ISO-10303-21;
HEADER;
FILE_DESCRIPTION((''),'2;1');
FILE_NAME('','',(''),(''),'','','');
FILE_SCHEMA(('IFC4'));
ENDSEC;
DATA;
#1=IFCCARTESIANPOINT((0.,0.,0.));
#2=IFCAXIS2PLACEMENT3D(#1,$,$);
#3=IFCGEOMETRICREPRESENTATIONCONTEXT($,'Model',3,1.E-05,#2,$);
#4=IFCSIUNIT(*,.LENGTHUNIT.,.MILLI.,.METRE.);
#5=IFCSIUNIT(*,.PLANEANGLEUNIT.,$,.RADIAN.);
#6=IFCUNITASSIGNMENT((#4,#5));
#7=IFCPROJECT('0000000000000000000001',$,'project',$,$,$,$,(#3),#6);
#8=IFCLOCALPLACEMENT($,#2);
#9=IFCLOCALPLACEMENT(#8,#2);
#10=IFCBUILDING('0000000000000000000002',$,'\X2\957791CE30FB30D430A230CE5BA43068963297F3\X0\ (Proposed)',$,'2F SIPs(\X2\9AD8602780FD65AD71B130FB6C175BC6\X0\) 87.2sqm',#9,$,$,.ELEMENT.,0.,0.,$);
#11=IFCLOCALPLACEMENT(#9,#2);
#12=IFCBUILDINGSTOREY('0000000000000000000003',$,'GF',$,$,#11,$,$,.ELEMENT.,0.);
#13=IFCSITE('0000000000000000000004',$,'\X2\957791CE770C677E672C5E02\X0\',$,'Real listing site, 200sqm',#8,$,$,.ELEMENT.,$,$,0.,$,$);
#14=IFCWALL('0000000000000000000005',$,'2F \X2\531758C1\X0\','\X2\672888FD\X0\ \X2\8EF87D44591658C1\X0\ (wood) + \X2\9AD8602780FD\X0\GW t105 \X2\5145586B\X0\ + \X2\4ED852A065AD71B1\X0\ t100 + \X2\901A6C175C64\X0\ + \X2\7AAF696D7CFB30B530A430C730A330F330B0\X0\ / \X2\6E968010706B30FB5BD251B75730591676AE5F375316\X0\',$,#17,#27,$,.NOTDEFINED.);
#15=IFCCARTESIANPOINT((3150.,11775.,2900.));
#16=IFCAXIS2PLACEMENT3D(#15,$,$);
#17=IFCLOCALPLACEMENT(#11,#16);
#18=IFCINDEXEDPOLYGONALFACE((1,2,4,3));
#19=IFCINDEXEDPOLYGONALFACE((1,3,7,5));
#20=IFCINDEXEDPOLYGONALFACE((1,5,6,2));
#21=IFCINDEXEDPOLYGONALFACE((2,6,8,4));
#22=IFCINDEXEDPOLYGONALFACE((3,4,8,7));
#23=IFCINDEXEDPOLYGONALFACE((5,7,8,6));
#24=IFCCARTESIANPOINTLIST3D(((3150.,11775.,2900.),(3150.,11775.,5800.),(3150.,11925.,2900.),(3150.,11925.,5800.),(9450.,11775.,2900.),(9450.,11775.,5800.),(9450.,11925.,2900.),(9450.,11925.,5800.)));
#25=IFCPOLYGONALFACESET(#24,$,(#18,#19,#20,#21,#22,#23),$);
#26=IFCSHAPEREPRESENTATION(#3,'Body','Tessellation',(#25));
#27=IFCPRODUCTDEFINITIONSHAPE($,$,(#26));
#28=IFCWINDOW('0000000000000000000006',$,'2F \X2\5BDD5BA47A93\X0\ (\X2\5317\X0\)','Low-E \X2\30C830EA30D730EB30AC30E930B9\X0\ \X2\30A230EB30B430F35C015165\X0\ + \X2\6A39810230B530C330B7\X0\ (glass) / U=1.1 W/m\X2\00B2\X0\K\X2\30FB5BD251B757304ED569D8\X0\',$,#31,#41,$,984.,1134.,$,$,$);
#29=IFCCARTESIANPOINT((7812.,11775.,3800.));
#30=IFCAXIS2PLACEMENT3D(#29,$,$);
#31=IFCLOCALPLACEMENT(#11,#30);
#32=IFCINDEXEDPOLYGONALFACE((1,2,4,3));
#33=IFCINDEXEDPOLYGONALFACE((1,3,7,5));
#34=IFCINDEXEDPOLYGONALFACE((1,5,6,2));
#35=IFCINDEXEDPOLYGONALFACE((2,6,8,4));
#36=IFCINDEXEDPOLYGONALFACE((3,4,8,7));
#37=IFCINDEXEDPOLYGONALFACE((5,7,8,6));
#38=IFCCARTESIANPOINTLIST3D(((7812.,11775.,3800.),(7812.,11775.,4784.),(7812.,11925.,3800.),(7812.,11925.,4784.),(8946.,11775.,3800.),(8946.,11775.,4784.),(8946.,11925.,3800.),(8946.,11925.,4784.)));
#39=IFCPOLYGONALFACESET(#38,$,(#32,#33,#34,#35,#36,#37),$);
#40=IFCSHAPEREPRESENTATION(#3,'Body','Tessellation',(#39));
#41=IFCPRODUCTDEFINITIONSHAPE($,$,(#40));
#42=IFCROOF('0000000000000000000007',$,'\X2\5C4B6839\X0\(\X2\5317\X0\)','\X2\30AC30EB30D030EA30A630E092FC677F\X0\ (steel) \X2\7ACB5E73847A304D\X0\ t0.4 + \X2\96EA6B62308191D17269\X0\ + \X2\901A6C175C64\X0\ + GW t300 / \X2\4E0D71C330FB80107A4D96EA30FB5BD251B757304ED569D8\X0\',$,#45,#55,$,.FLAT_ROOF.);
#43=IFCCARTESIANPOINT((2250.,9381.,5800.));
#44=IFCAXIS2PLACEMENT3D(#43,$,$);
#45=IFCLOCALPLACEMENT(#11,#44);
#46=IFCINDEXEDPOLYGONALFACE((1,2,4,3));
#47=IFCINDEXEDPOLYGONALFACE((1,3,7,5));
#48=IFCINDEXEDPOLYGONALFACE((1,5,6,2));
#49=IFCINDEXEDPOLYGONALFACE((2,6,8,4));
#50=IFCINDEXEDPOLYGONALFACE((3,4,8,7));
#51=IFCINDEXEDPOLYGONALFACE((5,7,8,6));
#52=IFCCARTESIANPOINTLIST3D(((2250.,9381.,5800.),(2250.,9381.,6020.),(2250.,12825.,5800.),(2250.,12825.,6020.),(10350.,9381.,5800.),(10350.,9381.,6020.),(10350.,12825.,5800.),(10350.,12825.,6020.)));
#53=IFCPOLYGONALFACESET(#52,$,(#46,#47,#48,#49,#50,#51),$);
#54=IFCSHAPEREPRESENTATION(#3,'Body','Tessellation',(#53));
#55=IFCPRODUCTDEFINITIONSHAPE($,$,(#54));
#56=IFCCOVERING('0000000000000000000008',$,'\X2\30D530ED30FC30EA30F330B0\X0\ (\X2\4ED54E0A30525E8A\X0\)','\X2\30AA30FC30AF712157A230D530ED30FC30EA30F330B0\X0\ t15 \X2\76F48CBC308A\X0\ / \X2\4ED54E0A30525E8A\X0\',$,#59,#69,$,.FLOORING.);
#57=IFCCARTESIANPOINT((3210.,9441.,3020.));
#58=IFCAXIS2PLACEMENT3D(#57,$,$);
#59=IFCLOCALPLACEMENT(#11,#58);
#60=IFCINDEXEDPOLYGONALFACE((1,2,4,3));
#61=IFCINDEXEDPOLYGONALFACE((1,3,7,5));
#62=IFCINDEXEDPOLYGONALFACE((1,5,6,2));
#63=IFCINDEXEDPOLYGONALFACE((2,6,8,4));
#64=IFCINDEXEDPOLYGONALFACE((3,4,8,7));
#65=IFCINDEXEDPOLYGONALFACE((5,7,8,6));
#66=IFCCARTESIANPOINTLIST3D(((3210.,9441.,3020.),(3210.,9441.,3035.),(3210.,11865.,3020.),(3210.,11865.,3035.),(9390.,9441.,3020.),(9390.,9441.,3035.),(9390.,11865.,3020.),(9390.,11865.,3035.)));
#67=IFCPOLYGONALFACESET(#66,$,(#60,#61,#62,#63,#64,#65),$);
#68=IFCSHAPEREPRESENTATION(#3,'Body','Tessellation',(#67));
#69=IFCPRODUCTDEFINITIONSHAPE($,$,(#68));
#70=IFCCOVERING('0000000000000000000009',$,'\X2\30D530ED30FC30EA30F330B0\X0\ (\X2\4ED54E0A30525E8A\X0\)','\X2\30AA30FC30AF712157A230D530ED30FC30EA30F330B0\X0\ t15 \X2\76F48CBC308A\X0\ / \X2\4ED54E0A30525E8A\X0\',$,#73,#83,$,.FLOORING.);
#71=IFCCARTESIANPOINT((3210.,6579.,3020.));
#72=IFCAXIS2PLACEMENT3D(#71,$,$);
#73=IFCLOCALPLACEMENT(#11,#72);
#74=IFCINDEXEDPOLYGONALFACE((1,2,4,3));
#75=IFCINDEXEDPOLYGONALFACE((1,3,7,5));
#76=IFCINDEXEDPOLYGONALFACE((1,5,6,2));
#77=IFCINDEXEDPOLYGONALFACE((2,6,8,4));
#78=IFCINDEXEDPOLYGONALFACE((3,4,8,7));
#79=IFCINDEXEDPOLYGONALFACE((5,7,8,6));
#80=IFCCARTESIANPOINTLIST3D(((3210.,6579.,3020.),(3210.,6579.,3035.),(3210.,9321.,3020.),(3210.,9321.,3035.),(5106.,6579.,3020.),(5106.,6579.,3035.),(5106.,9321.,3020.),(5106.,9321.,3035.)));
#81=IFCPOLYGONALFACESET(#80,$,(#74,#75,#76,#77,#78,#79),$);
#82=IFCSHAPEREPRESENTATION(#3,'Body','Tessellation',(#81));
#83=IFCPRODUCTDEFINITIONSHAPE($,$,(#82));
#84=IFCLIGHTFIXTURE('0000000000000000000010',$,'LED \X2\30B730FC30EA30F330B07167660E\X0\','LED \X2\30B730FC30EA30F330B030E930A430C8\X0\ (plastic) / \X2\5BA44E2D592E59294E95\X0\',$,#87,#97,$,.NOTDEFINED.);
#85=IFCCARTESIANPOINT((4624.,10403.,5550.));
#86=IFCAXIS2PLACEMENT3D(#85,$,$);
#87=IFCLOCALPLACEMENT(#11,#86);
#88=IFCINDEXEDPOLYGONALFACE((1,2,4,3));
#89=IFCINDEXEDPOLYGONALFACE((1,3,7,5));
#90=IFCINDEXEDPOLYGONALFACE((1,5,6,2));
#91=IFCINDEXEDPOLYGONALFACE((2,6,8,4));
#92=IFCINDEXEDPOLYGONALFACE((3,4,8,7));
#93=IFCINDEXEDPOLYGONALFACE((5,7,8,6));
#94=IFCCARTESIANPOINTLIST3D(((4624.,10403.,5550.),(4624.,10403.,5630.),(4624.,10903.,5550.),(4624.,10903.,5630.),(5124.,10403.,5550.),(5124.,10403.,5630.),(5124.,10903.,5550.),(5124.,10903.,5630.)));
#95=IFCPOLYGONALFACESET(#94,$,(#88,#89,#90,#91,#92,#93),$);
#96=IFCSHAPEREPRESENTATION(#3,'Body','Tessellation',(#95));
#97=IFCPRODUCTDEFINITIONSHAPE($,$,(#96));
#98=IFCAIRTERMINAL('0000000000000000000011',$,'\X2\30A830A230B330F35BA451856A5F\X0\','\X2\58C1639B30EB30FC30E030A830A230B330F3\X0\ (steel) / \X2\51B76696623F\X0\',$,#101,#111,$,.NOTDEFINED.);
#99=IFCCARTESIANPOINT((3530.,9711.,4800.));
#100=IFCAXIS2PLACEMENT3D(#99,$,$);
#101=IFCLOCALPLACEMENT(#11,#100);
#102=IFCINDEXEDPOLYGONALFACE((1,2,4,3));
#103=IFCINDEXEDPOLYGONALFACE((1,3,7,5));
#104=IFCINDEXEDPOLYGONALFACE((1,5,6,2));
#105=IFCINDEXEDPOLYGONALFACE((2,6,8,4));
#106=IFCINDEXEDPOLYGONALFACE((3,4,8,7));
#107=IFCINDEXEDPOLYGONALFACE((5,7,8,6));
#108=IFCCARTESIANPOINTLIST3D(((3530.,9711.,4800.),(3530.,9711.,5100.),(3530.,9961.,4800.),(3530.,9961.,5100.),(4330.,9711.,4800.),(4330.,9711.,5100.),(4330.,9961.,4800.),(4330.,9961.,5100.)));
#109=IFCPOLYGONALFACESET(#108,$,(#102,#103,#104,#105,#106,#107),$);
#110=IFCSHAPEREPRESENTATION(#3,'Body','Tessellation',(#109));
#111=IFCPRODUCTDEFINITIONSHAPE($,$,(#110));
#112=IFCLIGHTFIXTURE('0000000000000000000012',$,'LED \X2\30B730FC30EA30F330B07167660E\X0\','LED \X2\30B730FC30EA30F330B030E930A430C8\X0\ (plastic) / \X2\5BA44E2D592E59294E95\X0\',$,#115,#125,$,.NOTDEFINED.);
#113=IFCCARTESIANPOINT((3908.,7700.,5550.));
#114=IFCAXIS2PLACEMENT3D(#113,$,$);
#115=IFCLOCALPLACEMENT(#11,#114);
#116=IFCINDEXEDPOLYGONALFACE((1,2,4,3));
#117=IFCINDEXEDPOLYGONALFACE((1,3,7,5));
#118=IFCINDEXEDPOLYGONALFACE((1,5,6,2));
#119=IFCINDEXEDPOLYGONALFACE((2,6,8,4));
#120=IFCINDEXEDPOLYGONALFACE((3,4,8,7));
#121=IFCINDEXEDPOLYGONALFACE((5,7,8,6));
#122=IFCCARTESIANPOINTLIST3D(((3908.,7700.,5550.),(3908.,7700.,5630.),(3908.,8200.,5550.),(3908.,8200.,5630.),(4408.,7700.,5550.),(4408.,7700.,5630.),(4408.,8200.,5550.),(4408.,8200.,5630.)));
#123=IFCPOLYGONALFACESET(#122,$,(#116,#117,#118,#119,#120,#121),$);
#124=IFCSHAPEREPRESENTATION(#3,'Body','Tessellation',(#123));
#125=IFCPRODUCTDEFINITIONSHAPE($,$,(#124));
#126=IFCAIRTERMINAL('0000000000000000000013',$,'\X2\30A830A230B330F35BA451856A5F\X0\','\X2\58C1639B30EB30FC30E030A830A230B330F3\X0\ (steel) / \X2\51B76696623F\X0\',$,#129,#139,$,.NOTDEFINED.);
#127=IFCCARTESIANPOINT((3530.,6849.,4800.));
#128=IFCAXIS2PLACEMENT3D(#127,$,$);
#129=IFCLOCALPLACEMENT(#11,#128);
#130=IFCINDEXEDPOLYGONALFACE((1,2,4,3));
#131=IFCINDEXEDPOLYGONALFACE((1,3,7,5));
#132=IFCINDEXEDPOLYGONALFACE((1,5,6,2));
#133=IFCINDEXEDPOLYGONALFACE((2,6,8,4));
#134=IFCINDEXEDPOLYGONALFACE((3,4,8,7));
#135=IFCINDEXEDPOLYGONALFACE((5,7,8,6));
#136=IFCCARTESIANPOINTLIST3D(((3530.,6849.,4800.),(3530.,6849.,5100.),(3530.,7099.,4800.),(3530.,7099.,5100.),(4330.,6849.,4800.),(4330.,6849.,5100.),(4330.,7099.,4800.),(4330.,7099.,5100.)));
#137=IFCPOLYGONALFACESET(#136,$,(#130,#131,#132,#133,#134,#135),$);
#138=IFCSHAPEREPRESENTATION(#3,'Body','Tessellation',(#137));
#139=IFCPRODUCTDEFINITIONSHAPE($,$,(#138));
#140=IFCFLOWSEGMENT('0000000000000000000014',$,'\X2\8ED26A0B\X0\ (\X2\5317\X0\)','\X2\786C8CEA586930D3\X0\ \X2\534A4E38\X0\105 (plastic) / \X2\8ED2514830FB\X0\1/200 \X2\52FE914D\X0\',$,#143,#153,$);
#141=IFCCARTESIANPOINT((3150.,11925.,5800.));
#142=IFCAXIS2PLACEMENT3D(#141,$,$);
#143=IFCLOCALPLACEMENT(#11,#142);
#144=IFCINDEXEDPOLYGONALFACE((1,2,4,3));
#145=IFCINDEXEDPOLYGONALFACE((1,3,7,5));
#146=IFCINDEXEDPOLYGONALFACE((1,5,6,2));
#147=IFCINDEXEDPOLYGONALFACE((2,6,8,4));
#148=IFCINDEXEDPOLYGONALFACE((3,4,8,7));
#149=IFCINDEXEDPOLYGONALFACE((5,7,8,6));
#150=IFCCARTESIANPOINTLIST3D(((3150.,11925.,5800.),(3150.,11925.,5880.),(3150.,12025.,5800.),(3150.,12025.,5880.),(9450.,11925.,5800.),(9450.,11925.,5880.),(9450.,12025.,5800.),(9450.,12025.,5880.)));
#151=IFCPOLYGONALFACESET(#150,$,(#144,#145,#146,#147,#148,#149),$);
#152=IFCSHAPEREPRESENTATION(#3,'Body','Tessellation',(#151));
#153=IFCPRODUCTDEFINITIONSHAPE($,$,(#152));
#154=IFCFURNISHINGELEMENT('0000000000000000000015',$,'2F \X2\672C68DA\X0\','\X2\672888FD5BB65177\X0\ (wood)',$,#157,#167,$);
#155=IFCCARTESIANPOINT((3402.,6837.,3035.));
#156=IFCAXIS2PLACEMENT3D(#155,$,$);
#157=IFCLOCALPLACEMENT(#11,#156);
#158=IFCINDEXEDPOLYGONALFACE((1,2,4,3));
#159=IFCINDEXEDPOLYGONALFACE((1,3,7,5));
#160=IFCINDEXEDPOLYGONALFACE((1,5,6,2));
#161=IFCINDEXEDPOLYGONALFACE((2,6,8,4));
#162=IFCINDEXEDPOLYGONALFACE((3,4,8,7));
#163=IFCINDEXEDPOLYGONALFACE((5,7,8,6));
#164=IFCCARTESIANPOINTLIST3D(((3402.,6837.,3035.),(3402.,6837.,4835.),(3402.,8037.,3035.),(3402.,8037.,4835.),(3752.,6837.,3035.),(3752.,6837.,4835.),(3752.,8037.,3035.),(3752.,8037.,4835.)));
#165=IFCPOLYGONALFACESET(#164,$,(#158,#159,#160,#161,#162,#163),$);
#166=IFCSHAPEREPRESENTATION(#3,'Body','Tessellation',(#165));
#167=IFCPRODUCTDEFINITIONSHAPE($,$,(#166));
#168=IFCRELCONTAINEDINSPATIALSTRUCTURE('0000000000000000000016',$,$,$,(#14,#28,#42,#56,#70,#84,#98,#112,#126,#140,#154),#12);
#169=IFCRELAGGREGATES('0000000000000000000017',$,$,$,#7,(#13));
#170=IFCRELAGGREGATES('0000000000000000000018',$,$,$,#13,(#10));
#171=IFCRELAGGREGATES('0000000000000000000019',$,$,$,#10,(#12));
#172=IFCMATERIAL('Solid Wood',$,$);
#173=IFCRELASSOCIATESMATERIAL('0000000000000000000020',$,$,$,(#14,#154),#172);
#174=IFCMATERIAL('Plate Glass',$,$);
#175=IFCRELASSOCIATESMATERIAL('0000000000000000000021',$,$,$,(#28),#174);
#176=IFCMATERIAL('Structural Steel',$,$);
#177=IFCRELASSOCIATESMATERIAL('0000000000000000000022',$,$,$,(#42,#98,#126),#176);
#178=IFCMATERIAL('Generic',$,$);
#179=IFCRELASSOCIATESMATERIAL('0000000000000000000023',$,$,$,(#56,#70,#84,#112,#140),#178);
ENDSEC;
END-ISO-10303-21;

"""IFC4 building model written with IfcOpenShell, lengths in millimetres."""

from ifc_helpers import new_model, si_unit, frame, frame_2d, origin, place, context, project, spatial, rectangle, extrude, material, element, fill, save


model = new_model("IFC4")

# Units and contexts
model_context = context("Model", 3, precision=1e-05, world=origin())
ifc_project = project(units=[si_unit("LENGTHUNIT", "METRE", prefix="MILLI"), si_unit("PLANEANGLEUNIT", "RADIAN")], contexts=[model_context])

# Site, building, storey
site_placement = place(None, origin())
site = spatial("IfcSite", under=ifc_project, at=site_placement, Name="長野県松本市", ObjectType="Real listing site, 200sqm", CompositionType="ELEMENT", RefElevation=0.0)
building_placement = place(site_placement, origin())
building = spatial("IfcBuilding", under=site, at=building_placement, Name="長野・ピアノ室と防音 (Proposed)", ObjectType="2F SIPs(高性能断熱・気密) 87.2sqm", CompositionType="ELEMENT", ElevationOfRefHeight=0.0, ElevationOfTerrain=0.0)
storey_placement = place(building_placement, origin())
storey = spatial("IfcBuildingStorey", under=building, at=storey_placement, Name="GF", CompositionType="ELEMENT", Elevation=0.0)

# Shared definitions
ifc_material_1 = material(Name="Solid Wood")

# Wall, opening, window
wall_placement = place(storey_placement, frame((3150.0, 11775.0, 2900.0)))
wall = element("IfcWall", 1, at=wall_placement, inside=storey, material=ifc_material_1, Name="2F 北壁", Description="木製 軸組外壁 (wood) + 高性能GW t105 充填 + 付加断熱 t100 + 通気層 + 窯業系サイディング / 準耐火・寒冷地外皮強化", PredefinedType="NOTDEFINED", context=model_context, shape_type="SweptSolid", body=[
    extrude(rectangle(XDim=6300.0, YDim=150.0, at=frame_2d((3150.0, 75.0))), frame((3150.0, 11775.0, 2900.0)), (0.0, 0.0, 1.0), 2900.0),
])
opening_placement = place(storey_placement, frame((7812.0, 11775.0, 3800.0)))
opening = element("IfcOpeningElement", 2, at=opening_placement, cuts=wall, PredefinedType="NOTDEFINED", context=model_context, shape_type="SweptSolid", body=[
    extrude(rectangle(XDim=1134.0, YDim=150.0, at=frame_2d((567.0, 75.0))), frame((7812.0, 11775.0, 3800.0)), (0.0, 0.0, 1.0), 984.0),
])
ifc_material_2 = material(Name="Plate Glass")
window_placement = place(storey_placement, frame((7812.0, 11775.0, 3800.0)))
window = element("IfcWindow", 3, at=window_placement, inside=storey, material=ifc_material_2, Name="2F 寝室窓 (北)", Description="Low-E トリプルガラス アルゴン封入 + 樹脂サッシ (glass) / U=1.1 W/m²K・寒冷地仕様", OverallHeight=984.0, OverallWidth=1134.0, context=model_context, shape_type="SweptSolid", body=[
    extrude(rectangle(XDim=1134.0, YDim=150.0, at=frame_2d((567.0, 75.0))), frame((7812.0, 11775.0, 3800.0)), (0.0, 0.0, 1.0), 984.0),
])
fill(opening, window)

# Roof
ifc_material_3 = material(Name="Structural Steel")
for number, where, name in (
    (4, (2250.0, 9381.0, 5800.0), "屋根(北)"),
):
    element("IfcRoof", number, at=place(storey_placement, frame(where)), inside=storey, material=ifc_material_3, Name=name, Description="ガルバリウム鋼板 (steel) 立平葺き t0.4 + 雪止め金物 + 通気層 + GW t300 / 不燃・耐積雪・寒冷地仕様", PredefinedType="FLAT_ROOF", context=model_context, shape_type="SweptSolid", body=[
        extrude(rectangle(XDim=8100.0, YDim=3444.0, at=frame_2d((4050.0, 1722.0))), frame((2250.0, 9381.0, 5800.0)), (0.0, 0.0, 1.0), 220.0),
    ])

# Coverings
ifc_material_4 = material(Name="Generic")
covering_1_placement = place(storey_placement, frame((3210.0, 9441.0, 3020.0)))
element("IfcCovering", 5, at=covering_1_placement, inside=storey, material=ifc_material_4, Name="フローリング (仕上げ床)", Description="オーク無垢フローリング t15 直貼り / 仕上げ床", PredefinedType="FLOORING", context=model_context, shape_type="SweptSolid", body=[
    extrude(rectangle(XDim=6180.0, YDim=2424.0, at=frame_2d((3090.0, 1212.0))), frame((3210.0, 9441.0, 3020.0)), (0.0, 0.0, 1.0), 15.0),
])
covering_2_placement = place(storey_placement, frame((3210.0, 6579.0, 3020.0)))
element("IfcCovering", 6, at=covering_2_placement, inside=storey, material=ifc_material_4, Name="フローリング (仕上げ床)", Description="オーク無垢フローリング t15 直貼り / 仕上げ床", PredefinedType="FLOORING", context=model_context, shape_type="SweptSolid", body=[
    extrude(rectangle(XDim=1896.0, YDim=2742.0, at=frame_2d((948.0, 1371.0))), frame((3210.0, 6579.0, 3020.0)), (0.0, 0.0, 1.0), 15.0),
])

# Light fixture
light_fixture_1_placement = place(storey_placement, frame((4624.0, 10403.0, 5550.0)))
element("IfcLightFixture", 7, at=light_fixture_1_placement, inside=storey, material=ifc_material_4, Name="LED シーリング照明", Description="LED シーリングライト (plastic) / 室中央天井", PredefinedType="NOTDEFINED", context=model_context, shape_type="SweptSolid", body=[
    extrude(rectangle(XDim=500.0, YDim=500.0, at=frame_2d((250.0, 250.0))), frame((4624.0, 10403.0, 5550.0)), (0.0, 0.0, 1.0), 80.0),
])

# Air terminal
air_terminal_1_placement = place(storey_placement, frame((3530.0, 9711.0, 4800.0)))
element("IfcAirTerminal", 8, at=air_terminal_1_placement, inside=storey, material=ifc_material_3, Name="エアコン室内機", Description="壁掛ルームエアコン (steel) / 冷暖房", PredefinedType="NOTDEFINED", context=model_context, shape_type="SweptSolid", body=[
    extrude(rectangle(XDim=800.0, YDim=250.0, at=frame_2d((400.0, 125.0))), frame((3530.0, 9711.0, 4800.0)), (0.0, 0.0, 1.0), 300.0),
])

# Light fixture
light_fixture_2_placement = place(storey_placement, frame((3908.0, 7700.0, 5550.0)))
element("IfcLightFixture", 9, at=light_fixture_2_placement, inside=storey, material=ifc_material_4, Name="LED シーリング照明", Description="LED シーリングライト (plastic) / 室中央天井", PredefinedType="NOTDEFINED", context=model_context, shape_type="SweptSolid", body=[
    extrude(rectangle(XDim=500.0, YDim=500.0, at=frame_2d((250.0, 250.0))), frame((3908.0, 7700.0, 5550.0)), (0.0, 0.0, 1.0), 80.0),
])

# Air terminal
air_terminal_2_placement = place(storey_placement, frame((3530.0, 6849.0, 4800.0)))
element("IfcAirTerminal", 10, at=air_terminal_2_placement, inside=storey, material=ifc_material_3, Name="エアコン室内機", Description="壁掛ルームエアコン (steel) / 冷暖房", PredefinedType="NOTDEFINED", context=model_context, shape_type="SweptSolid", body=[
    extrude(rectangle(XDim=800.0, YDim=250.0, at=frame_2d((400.0, 125.0))), frame((3530.0, 6849.0, 4800.0)), (0.0, 0.0, 1.0), 300.0),
])

# Flow segment
flow_segment_placement = place(storey_placement, frame((3150.0, 11925.0, 5800.0)))
element("IfcFlowSegment", 11, at=flow_segment_placement, inside=storey, material=ifc_material_4, Name="軒樋 (北)", Description="硬質塩ビ 半丸105 (plastic) / 軒先・1/200 勾配", context=model_context, shape_type="SweptSolid", body=[
    extrude(rectangle(XDim=6300.0, YDim=100.0, at=frame_2d((3150.0, 50.0))), frame((3150.0, 11925.0, 5800.0)), (0.0, 0.0, 1.0), 80.0),
])

# Furnishing element
furnishing_placement = place(storey_placement, frame((3402.0, 6837.0, 3035.0)))
element("IfcFurnishingElement", 12, at=furnishing_placement, inside=storey, material=ifc_material_1, Name="2F 本棚", Description="木製家具 (wood)", context=model_context, shape_type="SweptSolid", body=[
    extrude(rectangle(XDim=350.0, YDim=1200.0, at=frame_2d((175.0, 600.0))), frame((3402.0, 6837.0, 3035.0)), (0.0, 0.0, 1.0), 1800.0),
])

save(model, "model.ifc")
